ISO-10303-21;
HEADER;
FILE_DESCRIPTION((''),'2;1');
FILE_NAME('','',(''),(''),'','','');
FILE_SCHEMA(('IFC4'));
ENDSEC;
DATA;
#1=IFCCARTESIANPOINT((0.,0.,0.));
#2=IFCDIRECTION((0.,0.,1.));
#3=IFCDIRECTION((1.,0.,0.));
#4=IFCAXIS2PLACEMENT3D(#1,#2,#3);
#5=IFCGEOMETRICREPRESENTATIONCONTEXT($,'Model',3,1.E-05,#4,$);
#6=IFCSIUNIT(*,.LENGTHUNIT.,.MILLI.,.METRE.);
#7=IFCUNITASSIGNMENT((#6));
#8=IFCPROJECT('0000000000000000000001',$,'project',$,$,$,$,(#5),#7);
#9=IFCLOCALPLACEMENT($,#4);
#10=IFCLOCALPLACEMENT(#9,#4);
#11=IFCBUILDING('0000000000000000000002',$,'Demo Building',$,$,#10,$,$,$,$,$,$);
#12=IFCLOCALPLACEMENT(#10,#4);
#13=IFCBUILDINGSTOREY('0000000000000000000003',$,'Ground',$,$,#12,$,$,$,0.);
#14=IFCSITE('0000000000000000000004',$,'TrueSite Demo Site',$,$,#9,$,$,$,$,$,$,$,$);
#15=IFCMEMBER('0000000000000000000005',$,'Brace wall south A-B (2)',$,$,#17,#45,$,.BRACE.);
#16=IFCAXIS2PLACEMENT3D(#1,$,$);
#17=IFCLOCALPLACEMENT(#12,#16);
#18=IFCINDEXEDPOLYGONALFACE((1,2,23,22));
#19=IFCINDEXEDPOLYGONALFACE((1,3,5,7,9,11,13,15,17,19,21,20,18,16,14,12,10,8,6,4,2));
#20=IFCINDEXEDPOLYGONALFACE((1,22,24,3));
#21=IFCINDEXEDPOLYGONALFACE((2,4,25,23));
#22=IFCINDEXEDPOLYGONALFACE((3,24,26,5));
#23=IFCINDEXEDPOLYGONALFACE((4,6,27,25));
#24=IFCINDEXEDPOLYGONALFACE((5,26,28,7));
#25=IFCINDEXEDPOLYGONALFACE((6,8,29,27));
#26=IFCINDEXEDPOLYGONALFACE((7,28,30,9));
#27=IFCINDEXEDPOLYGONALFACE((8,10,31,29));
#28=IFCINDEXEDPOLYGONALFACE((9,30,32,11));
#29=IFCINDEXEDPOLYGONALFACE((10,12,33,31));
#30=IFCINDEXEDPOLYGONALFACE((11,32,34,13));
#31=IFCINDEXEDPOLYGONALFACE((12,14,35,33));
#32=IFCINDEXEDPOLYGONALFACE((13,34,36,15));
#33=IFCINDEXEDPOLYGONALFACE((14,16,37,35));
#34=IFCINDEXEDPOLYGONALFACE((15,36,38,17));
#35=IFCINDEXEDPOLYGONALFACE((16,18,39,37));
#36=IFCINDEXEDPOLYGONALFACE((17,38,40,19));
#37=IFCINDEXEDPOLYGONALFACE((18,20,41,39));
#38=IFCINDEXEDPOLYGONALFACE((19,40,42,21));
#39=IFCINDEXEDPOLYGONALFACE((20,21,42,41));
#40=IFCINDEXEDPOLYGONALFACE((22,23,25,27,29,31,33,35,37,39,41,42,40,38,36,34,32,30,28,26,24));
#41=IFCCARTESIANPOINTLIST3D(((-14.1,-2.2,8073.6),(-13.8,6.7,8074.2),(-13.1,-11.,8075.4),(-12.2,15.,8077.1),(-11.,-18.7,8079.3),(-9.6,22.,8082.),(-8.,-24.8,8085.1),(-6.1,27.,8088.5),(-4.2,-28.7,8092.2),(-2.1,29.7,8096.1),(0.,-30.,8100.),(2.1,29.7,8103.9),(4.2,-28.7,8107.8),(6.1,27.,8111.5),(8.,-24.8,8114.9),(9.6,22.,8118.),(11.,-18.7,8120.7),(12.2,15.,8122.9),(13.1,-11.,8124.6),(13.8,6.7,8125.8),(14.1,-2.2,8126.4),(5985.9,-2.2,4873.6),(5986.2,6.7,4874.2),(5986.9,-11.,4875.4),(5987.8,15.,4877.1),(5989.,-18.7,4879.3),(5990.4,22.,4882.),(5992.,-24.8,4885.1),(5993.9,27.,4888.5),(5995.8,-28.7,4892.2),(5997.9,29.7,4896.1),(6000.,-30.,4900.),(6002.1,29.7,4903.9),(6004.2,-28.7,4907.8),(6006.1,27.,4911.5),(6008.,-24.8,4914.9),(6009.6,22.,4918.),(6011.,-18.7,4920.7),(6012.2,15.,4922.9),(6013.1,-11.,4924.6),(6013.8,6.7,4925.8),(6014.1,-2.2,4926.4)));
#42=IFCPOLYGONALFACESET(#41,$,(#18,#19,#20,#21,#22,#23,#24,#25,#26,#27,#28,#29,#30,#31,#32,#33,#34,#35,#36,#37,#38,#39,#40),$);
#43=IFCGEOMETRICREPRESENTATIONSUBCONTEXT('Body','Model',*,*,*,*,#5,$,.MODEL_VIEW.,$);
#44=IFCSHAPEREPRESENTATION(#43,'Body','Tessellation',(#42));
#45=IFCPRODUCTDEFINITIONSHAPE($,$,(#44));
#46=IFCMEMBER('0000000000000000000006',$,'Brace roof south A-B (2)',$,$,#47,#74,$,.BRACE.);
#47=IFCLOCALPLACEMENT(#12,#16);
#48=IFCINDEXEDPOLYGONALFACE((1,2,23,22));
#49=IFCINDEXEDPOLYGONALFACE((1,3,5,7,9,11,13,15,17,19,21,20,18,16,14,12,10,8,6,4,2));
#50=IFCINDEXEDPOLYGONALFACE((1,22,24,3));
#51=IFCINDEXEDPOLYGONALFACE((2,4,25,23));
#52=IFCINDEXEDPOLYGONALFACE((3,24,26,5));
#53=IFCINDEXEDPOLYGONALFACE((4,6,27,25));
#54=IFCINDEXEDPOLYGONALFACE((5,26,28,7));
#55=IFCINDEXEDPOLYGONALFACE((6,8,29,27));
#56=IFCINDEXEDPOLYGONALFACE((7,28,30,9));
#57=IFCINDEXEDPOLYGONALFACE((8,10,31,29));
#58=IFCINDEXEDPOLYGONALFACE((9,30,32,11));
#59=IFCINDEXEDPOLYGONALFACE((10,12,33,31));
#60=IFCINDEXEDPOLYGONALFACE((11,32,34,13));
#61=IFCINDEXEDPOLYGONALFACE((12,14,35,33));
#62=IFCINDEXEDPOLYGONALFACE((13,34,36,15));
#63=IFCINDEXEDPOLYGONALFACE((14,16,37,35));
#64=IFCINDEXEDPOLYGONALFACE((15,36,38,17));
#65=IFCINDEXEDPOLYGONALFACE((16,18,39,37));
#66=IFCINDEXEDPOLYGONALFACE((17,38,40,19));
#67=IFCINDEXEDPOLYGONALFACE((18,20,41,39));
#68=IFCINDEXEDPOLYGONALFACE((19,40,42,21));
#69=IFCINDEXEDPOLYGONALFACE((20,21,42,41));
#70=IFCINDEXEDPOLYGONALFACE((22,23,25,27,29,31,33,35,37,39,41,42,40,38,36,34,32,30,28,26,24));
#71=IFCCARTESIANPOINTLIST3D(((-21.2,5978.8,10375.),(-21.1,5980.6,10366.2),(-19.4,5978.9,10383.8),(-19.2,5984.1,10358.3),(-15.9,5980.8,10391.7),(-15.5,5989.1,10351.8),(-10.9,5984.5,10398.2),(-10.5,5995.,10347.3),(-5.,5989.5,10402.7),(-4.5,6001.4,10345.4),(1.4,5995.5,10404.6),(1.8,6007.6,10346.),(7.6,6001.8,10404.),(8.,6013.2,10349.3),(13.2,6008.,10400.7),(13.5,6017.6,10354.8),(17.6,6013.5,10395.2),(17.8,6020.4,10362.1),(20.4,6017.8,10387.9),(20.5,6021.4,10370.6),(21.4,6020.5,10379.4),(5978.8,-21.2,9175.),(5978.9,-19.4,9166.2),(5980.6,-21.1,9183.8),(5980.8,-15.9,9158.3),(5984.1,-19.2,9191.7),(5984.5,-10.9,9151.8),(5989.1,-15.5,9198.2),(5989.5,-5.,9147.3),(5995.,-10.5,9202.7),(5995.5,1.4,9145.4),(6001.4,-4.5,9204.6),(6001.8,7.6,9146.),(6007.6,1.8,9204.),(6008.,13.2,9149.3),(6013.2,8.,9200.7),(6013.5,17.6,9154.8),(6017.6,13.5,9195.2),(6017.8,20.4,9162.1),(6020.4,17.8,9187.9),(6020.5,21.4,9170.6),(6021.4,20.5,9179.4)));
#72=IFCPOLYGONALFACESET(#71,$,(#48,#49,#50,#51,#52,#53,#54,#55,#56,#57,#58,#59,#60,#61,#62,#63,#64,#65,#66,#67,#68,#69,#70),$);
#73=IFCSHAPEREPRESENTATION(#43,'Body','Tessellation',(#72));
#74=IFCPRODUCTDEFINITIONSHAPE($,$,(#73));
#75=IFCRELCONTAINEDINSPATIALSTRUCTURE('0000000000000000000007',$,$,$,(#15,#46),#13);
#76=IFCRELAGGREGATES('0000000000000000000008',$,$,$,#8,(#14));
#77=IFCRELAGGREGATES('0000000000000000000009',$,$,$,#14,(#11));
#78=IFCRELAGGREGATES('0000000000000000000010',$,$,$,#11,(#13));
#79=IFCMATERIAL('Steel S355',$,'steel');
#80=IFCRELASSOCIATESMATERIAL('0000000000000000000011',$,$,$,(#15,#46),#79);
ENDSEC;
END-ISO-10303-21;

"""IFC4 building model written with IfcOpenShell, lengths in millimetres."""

from ifc_helpers import new_model, si_unit, frame, origin_with_axes, place, context, subcontext, project, spatial, circle, extrude, material, element, save


model = new_model("IFC4")

# Units and contexts
model_context = context("Model", 3, precision=1e-05, world=origin_with_axes())
body_context = subcontext(model_context, "Body", "Model", "MODEL_VIEW")
ifc_project = project(units=[si_unit("LENGTHUNIT", "METRE", prefix="MILLI")], contexts=[model_context])

# Site, building, storey
site_placement = place(None, origin_with_axes())
site = spatial("IfcSite", under=ifc_project, at=site_placement, Name="TrueSite Demo Site")
building_placement = place(site_placement, origin_with_axes())
building = spatial("IfcBuilding", under=site, at=building_placement, Name="Demo Building")
storey_placement = place(building_placement, origin_with_axes())
storey = spatial("IfcBuildingStorey", under=building, at=storey_placement, Name="Ground", Elevation=0.0)

# Shared definitions
ifc_material_1 = material(Name="Steel S355", Category="steel")

# Members
member_1_placement = place(storey_placement, frame((6000.0, 0.0, 4900.0), z_axis=(-0.882353, 0.0, 0.470588), x_axis=(0.0, -1.0, 0.0)))
element("IfcMember", 1, at=member_1_placement, inside=storey, material=ifc_material_1, Name="Brace wall south A-B (2)", PredefinedType="BRACE", context=body_context, shape_type="SweptSolid", body=[
    extrude(circle(Radius=30.0), origin_with_axes(), (0.0, 0.0, 1.0), 6800.0),
])
member_2_placement = place(storey_placement, frame((6000.0, 0.0, 9175.0), z_axis=(-0.70014, 0.70014, 0.140028), x_axis=(-0.707107, -0.707107, 0.0)))
element("IfcMember", 2, at=member_2_placement, inside=storey, material=ifc_material_1, Name="Brace roof south A-B (2)", PredefinedType="BRACE", context=body_context, shape_type="SweptSolid", body=[
    extrude(circle(Radius=30.0), origin_with_axes(), (0.0, 0.0, 1.0), 8569.7),
])

save(model, "model.ifc")
